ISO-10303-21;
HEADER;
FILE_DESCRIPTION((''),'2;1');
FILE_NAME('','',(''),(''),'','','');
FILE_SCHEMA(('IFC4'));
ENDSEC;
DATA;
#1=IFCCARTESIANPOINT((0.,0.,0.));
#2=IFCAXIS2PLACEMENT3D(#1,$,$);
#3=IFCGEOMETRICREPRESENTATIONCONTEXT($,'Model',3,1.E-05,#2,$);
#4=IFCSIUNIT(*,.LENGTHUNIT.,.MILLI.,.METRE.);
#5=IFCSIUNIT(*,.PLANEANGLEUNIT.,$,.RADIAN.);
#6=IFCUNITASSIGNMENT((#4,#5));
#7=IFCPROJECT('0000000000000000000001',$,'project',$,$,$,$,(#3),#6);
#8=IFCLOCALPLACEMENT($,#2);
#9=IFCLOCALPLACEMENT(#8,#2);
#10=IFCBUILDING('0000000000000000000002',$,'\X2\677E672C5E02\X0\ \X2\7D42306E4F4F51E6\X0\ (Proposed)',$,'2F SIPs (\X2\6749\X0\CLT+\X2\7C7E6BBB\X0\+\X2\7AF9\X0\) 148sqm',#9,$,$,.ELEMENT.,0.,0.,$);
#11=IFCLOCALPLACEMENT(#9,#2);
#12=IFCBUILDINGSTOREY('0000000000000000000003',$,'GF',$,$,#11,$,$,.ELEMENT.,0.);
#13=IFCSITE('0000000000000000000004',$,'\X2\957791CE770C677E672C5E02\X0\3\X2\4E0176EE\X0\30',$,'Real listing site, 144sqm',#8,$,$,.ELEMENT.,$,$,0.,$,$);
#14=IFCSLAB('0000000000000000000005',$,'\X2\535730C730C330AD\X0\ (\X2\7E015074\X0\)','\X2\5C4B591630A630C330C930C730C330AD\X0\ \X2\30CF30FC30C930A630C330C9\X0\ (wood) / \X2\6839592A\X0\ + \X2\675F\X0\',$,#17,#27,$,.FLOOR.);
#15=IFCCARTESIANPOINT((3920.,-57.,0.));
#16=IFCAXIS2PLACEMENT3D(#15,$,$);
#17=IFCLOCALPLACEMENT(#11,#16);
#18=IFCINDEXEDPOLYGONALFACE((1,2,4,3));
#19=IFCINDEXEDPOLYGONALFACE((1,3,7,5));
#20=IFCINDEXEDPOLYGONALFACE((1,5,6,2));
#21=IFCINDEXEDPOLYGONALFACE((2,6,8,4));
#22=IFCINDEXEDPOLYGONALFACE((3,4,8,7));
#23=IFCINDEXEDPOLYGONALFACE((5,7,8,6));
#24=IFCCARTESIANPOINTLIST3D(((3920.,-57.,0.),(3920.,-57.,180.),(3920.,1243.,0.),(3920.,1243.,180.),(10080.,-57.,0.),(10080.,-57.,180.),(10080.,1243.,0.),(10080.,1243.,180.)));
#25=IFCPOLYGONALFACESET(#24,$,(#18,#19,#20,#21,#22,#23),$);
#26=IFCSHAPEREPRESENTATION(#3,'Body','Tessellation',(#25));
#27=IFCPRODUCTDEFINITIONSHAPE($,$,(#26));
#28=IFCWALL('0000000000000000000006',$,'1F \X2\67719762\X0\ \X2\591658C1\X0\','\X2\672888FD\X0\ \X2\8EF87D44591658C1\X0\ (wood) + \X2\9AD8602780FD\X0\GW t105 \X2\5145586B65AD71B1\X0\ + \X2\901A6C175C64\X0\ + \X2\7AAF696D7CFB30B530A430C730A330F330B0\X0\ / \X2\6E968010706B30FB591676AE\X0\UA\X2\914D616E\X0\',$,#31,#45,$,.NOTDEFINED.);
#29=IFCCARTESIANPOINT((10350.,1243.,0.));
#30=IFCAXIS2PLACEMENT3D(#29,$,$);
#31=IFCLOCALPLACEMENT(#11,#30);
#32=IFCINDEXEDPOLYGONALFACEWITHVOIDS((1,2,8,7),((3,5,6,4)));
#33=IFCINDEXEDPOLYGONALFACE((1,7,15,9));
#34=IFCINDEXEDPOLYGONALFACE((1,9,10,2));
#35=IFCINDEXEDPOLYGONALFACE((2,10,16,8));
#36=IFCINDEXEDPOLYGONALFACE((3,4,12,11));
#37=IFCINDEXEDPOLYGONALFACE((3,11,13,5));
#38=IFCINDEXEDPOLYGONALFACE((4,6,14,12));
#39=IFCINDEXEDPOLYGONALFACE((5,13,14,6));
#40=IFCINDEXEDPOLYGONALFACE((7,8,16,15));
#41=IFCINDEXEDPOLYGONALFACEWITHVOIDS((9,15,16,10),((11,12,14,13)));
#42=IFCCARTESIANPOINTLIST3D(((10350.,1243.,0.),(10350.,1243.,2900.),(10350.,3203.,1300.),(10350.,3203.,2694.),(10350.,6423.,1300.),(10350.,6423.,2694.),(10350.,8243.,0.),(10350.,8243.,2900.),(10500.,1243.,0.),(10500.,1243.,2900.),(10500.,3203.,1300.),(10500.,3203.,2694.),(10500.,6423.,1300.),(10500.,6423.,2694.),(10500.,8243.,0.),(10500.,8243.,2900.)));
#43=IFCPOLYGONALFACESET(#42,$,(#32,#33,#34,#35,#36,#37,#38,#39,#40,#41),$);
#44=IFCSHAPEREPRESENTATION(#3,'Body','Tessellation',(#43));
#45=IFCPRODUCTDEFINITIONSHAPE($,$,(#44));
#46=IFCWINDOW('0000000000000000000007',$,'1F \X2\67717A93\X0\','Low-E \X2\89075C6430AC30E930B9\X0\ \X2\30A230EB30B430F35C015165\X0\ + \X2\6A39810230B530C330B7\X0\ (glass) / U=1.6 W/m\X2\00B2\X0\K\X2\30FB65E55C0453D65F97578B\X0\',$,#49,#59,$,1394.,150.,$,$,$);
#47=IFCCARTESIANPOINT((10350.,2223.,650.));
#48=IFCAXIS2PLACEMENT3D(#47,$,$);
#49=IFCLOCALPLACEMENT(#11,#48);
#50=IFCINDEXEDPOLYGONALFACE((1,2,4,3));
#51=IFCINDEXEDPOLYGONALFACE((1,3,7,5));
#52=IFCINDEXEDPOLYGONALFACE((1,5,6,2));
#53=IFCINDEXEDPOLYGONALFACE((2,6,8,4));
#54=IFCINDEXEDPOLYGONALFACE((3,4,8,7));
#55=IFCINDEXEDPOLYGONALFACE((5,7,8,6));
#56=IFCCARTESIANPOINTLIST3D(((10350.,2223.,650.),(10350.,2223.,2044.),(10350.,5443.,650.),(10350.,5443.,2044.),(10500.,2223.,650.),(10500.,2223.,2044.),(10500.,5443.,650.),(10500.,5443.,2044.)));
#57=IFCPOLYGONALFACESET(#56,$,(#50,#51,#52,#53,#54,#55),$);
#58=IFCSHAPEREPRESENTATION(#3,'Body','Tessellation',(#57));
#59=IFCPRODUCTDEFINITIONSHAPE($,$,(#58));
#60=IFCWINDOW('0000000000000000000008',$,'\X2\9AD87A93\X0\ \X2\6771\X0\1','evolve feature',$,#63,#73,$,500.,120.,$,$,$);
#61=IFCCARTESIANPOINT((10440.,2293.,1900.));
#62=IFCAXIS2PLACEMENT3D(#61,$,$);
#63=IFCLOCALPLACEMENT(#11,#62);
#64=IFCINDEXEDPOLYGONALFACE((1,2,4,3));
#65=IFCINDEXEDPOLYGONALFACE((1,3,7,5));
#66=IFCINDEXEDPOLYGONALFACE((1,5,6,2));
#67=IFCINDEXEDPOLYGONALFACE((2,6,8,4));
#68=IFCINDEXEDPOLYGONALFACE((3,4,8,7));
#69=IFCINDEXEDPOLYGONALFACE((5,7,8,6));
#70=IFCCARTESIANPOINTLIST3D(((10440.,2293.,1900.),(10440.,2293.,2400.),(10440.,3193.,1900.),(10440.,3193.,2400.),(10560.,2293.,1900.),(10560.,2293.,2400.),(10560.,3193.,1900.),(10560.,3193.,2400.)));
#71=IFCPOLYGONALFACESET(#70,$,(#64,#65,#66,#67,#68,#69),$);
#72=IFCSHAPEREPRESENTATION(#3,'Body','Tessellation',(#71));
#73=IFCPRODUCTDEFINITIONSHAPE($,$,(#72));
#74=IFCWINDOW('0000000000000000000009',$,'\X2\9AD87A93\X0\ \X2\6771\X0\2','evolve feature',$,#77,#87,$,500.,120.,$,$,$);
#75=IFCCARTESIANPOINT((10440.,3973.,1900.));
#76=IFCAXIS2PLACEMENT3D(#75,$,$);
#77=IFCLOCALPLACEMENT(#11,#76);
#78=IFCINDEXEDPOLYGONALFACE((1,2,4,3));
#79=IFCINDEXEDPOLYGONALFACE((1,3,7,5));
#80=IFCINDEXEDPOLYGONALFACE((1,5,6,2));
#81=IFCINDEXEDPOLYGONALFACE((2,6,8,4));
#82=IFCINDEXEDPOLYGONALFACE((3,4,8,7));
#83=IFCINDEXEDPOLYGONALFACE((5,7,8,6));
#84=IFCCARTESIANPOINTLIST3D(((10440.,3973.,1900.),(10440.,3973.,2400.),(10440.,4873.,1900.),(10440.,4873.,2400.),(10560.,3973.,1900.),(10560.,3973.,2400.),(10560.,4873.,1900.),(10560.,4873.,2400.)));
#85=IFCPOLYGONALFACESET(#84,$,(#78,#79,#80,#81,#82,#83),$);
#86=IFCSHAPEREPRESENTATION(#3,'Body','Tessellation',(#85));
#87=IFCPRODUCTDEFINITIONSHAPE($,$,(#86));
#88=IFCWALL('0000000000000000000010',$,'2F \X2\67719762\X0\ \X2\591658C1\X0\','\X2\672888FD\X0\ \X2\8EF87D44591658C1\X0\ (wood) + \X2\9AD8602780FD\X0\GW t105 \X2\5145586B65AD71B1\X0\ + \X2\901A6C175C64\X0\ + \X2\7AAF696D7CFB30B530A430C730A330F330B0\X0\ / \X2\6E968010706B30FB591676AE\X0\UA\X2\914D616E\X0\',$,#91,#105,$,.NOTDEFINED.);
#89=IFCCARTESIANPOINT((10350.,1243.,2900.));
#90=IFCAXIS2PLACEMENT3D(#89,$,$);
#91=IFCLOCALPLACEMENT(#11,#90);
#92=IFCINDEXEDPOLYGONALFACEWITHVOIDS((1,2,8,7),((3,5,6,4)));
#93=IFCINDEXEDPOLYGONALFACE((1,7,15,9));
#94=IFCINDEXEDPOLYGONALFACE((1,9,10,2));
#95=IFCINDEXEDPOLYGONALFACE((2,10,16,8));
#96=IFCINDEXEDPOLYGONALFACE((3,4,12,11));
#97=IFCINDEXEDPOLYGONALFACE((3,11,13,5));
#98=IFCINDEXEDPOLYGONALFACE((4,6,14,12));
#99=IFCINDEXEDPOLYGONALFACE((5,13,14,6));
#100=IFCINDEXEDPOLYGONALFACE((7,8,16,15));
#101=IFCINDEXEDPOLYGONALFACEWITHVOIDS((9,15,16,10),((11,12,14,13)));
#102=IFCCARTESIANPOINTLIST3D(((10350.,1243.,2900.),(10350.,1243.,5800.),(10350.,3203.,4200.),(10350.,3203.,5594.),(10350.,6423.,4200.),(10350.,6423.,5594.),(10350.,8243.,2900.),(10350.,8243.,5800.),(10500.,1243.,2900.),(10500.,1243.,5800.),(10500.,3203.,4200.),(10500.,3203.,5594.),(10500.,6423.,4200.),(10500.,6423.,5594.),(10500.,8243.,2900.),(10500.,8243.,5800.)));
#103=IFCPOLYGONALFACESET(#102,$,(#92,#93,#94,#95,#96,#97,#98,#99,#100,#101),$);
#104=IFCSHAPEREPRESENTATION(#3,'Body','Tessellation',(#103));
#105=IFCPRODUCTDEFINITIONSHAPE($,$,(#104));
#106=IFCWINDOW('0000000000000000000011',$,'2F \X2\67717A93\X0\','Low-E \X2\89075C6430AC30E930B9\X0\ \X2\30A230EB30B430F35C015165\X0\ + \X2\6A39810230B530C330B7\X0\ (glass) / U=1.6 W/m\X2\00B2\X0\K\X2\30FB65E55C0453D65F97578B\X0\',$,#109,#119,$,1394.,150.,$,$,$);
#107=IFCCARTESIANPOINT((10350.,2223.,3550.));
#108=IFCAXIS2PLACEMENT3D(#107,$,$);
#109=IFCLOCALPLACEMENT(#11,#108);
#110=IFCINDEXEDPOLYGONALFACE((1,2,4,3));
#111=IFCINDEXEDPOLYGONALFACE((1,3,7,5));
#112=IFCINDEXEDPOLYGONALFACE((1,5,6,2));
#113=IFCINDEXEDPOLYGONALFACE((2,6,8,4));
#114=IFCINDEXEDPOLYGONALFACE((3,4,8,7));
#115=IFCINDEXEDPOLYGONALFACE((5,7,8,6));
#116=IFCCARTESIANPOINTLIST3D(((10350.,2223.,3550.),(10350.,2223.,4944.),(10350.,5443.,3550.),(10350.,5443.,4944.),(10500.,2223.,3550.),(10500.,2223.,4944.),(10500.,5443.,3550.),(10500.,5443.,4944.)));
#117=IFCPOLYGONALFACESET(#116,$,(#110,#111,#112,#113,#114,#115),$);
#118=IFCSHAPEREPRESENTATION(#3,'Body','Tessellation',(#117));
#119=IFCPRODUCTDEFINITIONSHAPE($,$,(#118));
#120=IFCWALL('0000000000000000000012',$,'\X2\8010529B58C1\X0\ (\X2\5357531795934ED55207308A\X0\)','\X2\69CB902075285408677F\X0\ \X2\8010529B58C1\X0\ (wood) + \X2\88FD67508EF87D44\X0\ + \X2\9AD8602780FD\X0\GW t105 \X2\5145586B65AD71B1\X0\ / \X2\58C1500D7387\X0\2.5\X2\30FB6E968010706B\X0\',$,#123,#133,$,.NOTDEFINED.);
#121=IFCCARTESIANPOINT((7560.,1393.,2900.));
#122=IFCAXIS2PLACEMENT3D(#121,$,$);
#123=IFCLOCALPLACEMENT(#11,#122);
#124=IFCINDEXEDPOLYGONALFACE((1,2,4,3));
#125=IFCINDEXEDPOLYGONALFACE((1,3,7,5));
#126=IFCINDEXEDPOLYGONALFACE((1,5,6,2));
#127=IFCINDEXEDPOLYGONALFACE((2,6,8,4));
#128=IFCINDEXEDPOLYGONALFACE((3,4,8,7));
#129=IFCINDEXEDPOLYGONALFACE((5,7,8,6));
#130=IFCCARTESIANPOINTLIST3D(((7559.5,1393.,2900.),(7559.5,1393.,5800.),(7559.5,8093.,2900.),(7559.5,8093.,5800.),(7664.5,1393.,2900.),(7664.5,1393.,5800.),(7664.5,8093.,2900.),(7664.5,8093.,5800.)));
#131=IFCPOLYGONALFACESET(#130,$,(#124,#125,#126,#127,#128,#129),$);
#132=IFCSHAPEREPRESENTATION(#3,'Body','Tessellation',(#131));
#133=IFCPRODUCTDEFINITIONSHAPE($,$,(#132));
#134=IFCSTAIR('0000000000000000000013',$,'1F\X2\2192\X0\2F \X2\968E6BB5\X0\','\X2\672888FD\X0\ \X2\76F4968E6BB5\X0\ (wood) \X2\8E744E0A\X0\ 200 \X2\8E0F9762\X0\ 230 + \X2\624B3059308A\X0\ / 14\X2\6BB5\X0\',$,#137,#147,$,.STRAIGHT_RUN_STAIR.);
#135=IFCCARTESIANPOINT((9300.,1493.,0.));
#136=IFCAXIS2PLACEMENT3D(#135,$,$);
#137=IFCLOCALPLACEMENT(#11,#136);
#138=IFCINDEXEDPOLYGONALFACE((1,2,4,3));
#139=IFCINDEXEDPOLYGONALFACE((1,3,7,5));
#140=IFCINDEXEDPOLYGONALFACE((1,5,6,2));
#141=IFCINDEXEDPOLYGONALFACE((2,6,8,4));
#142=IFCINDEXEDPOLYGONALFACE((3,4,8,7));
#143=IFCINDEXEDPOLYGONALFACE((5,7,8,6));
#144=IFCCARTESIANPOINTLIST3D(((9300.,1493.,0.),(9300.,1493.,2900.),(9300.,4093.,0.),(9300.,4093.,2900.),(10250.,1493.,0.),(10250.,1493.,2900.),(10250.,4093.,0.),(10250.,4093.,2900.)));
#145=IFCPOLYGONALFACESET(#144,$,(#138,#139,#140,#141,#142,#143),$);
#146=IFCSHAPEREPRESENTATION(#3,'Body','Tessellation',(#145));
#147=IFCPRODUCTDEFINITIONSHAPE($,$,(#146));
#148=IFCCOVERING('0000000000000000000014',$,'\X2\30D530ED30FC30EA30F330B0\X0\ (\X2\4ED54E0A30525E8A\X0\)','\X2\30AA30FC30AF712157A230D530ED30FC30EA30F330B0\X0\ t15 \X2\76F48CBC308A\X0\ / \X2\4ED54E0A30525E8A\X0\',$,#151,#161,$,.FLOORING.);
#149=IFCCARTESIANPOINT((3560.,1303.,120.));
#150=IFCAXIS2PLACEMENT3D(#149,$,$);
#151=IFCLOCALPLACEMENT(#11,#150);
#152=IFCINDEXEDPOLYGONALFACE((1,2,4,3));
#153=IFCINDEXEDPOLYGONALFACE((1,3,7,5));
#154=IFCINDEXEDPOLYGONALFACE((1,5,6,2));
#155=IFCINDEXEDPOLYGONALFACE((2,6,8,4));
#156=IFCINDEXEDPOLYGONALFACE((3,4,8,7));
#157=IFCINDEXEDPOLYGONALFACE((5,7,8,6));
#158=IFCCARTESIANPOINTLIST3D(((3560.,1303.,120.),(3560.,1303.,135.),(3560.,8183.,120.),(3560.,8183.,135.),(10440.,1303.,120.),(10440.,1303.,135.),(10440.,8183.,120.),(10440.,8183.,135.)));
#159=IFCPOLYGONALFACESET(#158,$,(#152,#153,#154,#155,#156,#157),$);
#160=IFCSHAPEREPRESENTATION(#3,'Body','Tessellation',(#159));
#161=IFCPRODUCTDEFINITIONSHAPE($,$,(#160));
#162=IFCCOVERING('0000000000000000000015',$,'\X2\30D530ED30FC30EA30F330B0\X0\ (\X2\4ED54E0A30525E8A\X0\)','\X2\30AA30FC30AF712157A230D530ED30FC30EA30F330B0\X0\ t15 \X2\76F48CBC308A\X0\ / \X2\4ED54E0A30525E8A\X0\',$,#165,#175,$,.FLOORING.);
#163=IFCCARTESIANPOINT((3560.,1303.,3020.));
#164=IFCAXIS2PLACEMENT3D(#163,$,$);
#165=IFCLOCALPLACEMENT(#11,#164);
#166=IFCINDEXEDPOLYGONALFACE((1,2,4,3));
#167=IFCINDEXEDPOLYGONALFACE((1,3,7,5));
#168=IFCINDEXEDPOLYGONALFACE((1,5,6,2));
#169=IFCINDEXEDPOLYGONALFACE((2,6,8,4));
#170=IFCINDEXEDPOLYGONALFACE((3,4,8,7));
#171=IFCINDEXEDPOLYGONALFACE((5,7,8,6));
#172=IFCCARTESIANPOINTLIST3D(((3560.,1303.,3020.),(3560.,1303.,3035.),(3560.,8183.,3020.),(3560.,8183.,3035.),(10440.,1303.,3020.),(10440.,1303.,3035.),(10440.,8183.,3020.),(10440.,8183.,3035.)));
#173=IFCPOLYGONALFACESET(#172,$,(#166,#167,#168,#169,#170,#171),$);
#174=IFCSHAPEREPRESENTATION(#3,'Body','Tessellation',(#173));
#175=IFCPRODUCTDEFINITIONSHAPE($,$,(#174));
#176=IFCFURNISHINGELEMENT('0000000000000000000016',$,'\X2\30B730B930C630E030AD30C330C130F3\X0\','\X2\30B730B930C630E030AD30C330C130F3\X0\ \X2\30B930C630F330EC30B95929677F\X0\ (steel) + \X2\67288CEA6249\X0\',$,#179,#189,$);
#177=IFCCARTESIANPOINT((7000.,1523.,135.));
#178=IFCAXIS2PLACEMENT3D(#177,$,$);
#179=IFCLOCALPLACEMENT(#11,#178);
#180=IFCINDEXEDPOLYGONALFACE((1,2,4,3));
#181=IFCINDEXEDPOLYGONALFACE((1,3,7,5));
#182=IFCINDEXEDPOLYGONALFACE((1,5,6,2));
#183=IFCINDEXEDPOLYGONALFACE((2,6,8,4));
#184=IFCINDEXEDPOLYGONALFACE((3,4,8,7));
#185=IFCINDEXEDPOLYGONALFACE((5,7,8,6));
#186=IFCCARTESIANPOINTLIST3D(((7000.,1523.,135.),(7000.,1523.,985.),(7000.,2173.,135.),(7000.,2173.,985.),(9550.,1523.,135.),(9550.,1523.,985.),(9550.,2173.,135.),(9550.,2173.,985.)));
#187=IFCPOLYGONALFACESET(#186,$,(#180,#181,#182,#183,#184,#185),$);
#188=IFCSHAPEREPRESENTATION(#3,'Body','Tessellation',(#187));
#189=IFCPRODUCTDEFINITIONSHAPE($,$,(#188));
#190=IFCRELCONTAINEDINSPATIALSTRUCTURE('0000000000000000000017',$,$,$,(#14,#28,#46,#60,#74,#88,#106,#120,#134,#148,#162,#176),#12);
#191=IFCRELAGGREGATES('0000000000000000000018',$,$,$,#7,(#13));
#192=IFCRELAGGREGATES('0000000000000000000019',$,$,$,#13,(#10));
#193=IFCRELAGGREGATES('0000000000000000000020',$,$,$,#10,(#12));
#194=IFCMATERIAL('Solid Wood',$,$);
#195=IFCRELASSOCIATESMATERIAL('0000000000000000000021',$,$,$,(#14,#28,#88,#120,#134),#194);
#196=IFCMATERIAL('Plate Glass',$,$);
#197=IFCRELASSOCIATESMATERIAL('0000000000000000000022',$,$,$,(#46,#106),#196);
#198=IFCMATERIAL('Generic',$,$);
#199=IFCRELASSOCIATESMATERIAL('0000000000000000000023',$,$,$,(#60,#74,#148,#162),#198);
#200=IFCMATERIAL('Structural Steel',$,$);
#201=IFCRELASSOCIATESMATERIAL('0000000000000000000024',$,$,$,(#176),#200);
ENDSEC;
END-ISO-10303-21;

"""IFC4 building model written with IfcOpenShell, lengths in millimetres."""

from ifc_helpers import new_model, si_unit, frame, frame_2d, origin, place, context, project, spatial, rectangle, extrude, material, element, fill, save


model = new_model("IFC4")

# Units and contexts
model_context = context("Model", 3, precision=1e-05, world=origin())
ifc_project = project(units=[si_unit("LENGTHUNIT", "METRE", prefix="MILLI"), si_unit("PLANEANGLEUNIT", "RADIAN")], contexts=[model_context])

# Site, building, storey
site_placement = place(None, origin())
site = spatial("IfcSite", under=ifc_project, at=site_placement, Name="長野県松本市3丁目30", ObjectType="Real listing site, 144sqm", CompositionType="ELEMENT", RefElevation=0.0)
building_placement = place(site_placement, origin())
building = spatial("IfcBuilding", under=site, at=building_placement, Name="松本市 終の住処 (Proposed)", ObjectType="2F SIPs (杉CLT+籾殻+竹) 148sqm", CompositionType="ELEMENT", ElevationOfRefHeight=0.0, ElevationOfTerrain=0.0)
storey_placement = place(building_placement, origin())
storey = spatial("IfcBuildingStorey", under=building, at=storey_placement, Name="GF", CompositionType="ELEMENT", Elevation=0.0)

# Slab
ifc_material_1 = material(Name="Solid Wood")
slab_placement = place(storey_placement, frame((3920.0, -57.0, 0.0)))
element("IfcSlab", 1, at=slab_placement, inside=storey, material=ifc_material_1, Name="南デッキ (縁側)", Description="屋外ウッドデッキ ハードウッド (wood) / 根太 + 束", PredefinedType="FLOOR", context=model_context, shape_type="SweptSolid", body=[
    extrude(rectangle(XDim=6160.0, YDim=1300.0, at=frame_2d((3080.0, 650.0))), frame((3920.0, -57.0, 0.0)), (0.0, 0.0, 1.0), 180.0),
])

# Wall, openings, windows
wall_1_placement = place(storey_placement, frame((10350.0, 1243.0, 0.0)))
wall_1 = element("IfcWall", 2, at=wall_1_placement, inside=storey, material=ifc_material_1, Name="1F 東面 外壁", Description="木製 軸組外壁 (wood) + 高性能GW t105 充填断熱 + 通気層 + 窯業系サイディング / 準耐火・外皮UA配慮", PredefinedType="NOTDEFINED", context=model_context, shape_type="SweptSolid", body=[
    extrude(rectangle(XDim=150.0, YDim=7000.0, at=frame_2d((75.0, 3500.0))), frame((10350.0, 1243.0, 0.0)), (0.0, 0.0, 1.0), 2900.0),
])
opening_1_placement = place(storey_placement, frame((10350.0, 2223.0, 650.0)))
opening_1 = element("IfcOpeningElement", 3, at=opening_1_placement, cuts=wall_1, PredefinedType="NOTDEFINED", context=model_context, shape_type="SweptSolid", body=[
    extrude(rectangle(XDim=150.0, YDim=3220.0, at=frame_2d((75.0, 1610.0))), frame((10350.0, 2223.0, 650.0)), (0.0, 0.0, 1.0), 1394.0),
])
opening_2_placement = place(storey_placement, frame((10440.0, 2293.0, 1900.0)))
opening_2 = element("IfcOpeningElement", 4, at=opening_2_placement, cuts=wall_1, PredefinedType="NOTDEFINED", context=model_context, shape_type="SweptSolid", body=[
    extrude(rectangle(XDim=120.0, YDim=900.0, at=frame_2d((60.0, 450.0))), frame((10440.0, 2293.0, 1900.0)), (0.0, 0.0, 1.0), 500.0),
])
opening_3_placement = place(storey_placement, frame((10440.0, 3973.0, 1900.0)))
opening_3 = element("IfcOpeningElement", 5, at=opening_3_placement, cuts=wall_1, PredefinedType="NOTDEFINED", context=model_context, shape_type="SweptSolid", body=[
    extrude(rectangle(XDim=120.0, YDim=900.0, at=frame_2d((60.0, 450.0))), frame((10440.0, 3973.0, 1900.0)), (0.0, 0.0, 1.0), 500.0),
])
ifc_material_2 = material(Name="Plate Glass")
window_1_placement = place(storey_placement, frame((10350.0, 2223.0, 650.0)))
window_1 = element("IfcWindow", 6, at=window_1_placement, inside=storey, material=ifc_material_2, Name="1F 東窓", Description="Low-E 複層ガラス アルゴン封入 + 樹脂サッシ (glass) / U=1.6 W/m²K・日射取得型", OverallHeight=1394.0, OverallWidth=150.0, context=model_context, shape_type="SweptSolid", body=[
    extrude(rectangle(XDim=150.0, YDim=3220.0, at=frame_2d((75.0, 1610.0))), frame((10350.0, 2223.0, 650.0)), (0.0, 0.0, 1.0), 1394.0),
])
fill(opening_1, window_1)
ifc_material_3 = material(Name="Generic")
window_2_placement = place(storey_placement, frame((10440.0, 2293.0, 1900.0)))
window_2 = element("IfcWindow", 7, at=window_2_placement, inside=storey, material=ifc_material_3, Name="高窓 東1", Description="evolve feature", OverallHeight=500.0, OverallWidth=120.0, context=model_context, shape_type="SweptSolid", body=[
    extrude(rectangle(XDim=120.0, YDim=900.0, at=frame_2d((60.0, 450.0))), frame((10440.0, 2293.0, 1900.0)), (0.0, 0.0, 1.0), 500.0),
])
fill(opening_2, window_2)
window_3_placement = place(storey_placement, frame((10440.0, 3973.0, 1900.0)))
window_3 = element("IfcWindow", 8, at=window_3_placement, inside=storey, material=ifc_material_3, Name="高窓 東2", Description="evolve feature", OverallHeight=500.0, OverallWidth=120.0, context=model_context, shape_type="SweptSolid", body=[
    extrude(rectangle(XDim=120.0, YDim=900.0, at=frame_2d((60.0, 450.0))), frame((10440.0, 3973.0, 1900.0)), (0.0, 0.0, 1.0), 500.0),
])
fill(opening_3, window_3)

# Wall, opening, window
wall_2_placement = place(storey_placement, frame((10350.0, 1243.0, 2900.0)))
wall_2 = element("IfcWall", 9, at=wall_2_placement, inside=storey, material=ifc_material_1, Name="2F 東面 外壁", Description="木製 軸組外壁 (wood) + 高性能GW t105 充填断熱 + 通気層 + 窯業系サイディング / 準耐火・外皮UA配慮", PredefinedType="NOTDEFINED", context=model_context, shape_type="SweptSolid", body=[
    extrude(rectangle(XDim=150.0, YDim=7000.0, at=frame_2d((75.0, 3500.0))), frame((10350.0, 1243.0, 2900.0)), (0.0, 0.0, 1.0), 2900.0),
])
opening_4_placement = place(storey_placement, frame((10350.0, 2223.0, 3550.0)))
opening_4 = element("IfcOpeningElement", 10, at=opening_4_placement, cuts=wall_2, PredefinedType="NOTDEFINED", context=model_context, shape_type="SweptSolid", body=[
    extrude(rectangle(XDim=150.0, YDim=3220.0, at=frame_2d((75.0, 1610.0))), frame((10350.0, 2223.0, 3550.0)), (0.0, 0.0, 1.0), 1394.0),
])
window_4_placement = place(storey_placement, frame((10350.0, 2223.0, 3550.0)))
window_4 = element("IfcWindow", 11, at=window_4_placement, inside=storey, material=ifc_material_2, Name="2F 東窓", Description="Low-E 複層ガラス アルゴン封入 + 樹脂サッシ (glass) / U=1.6 W/m²K・日射取得型", OverallHeight=1394.0, OverallWidth=150.0, context=model_context, shape_type="SweptSolid", body=[
    extrude(rectangle(XDim=150.0, YDim=3220.0, at=frame_2d((75.0, 1610.0))), frame((10350.0, 2223.0, 3550.0)), (0.0, 0.0, 1.0), 1394.0),
])
fill(opening_4, window_4)

# Wall
wall_3_placement = place(storey_placement, frame((7560.0, 1393.0, 2900.0)))
element("IfcWall", 12, at=wall_3_placement, inside=storey, material=ifc_material_1, Name="耐力壁 (南北間仕切り)", Description="構造用合板 耐力壁 (wood) + 製材軸組 + 高性能GW t105 充填断熱 / 壁倍率2.5・準耐火", PredefinedType="NOTDEFINED", context=model_context, shape_type="SweptSolid", body=[
    extrude(rectangle(XDim=105.0, YDim=6700.0, at=frame_2d((52.0, 3350.0))), frame((7560.0, 1393.0, 2900.0)), (0.0, 0.0, 1.0), 2900.0),
])

# Stair
stair_placement = place(storey_placement, frame((9300.0, 1493.0, 0.0)))
element("IfcStair", 13, at=stair_placement, inside=storey, material=ifc_material_1, Name="1F→2F 階段", Description="木製 直階段 (wood) 蹴上 200 踏面 230 + 手すり / 14段", PredefinedType="STRAIGHT_RUN_STAIR", context=model_context, shape_type="SweptSolid", body=[
    extrude(rectangle(XDim=950.0, YDim=2600.0, at=frame_2d((475.0, 1300.0))), frame((9300.0, 1493.0, 0.0)), (0.0, 0.0, 1.0), 2900.0),
])

# Coverings
covering_1_placement = place(storey_placement, frame((3560.0, 1303.0, 120.0)))
element("IfcCovering", 14, at=covering_1_placement, inside=storey, material=ifc_material_3, Name="フローリング (仕上げ床)", Description="オーク無垢フローリング t15 直貼り / 仕上げ床", PredefinedType="FLOORING", context=model_context, shape_type="SweptSolid", body=[
    extrude(rectangle(XDim=6880.0, YDim=6880.0, at=frame_2d((3440.0, 3440.0))), frame((3560.0, 1303.0, 120.0)), (0.0, 0.0, 1.0), 15.0),
])
covering_2_placement = place(storey_placement, frame((3560.0, 1303.0, 3020.0)))
element("IfcCovering", 15, at=covering_2_placement, inside=storey, material=ifc_material_3, Name="フローリング (仕上げ床)", Description="オーク無垢フローリング t15 直貼り / 仕上げ床", PredefinedType="FLOORING", context=model_context, shape_type="SweptSolid", body=[
    extrude(rectangle(XDim=6880.0, YDim=6880.0, at=frame_2d((3440.0, 3440.0))), frame((3560.0, 1303.0, 3020.0)), (0.0, 0.0, 1.0), 15.0),
])

# Furnishing element
ifc_material_4 = material(Name="Structural Steel")
furnishing_1_placement = place(storey_placement, frame((7000.0, 1523.0, 135.0)))
element("IfcFurnishingElement", 16, at=furnishing_1_placement, inside=storey, material=ifc_material_4, Name="システムキッチン", Description="システムキッチン ステンレス天板 (steel) + 木質扉", context=model_context, shape_type="SweptSolid", body=[
    extrude(rectangle(XDim=2550.0, YDim=650.0, at=frame_2d((1275.0, 325.0))), frame((7000.0, 1523.0, 135.0)), (0.0, 0.0, 1.0), 850.0),
])

save(model, "model.ifc")
